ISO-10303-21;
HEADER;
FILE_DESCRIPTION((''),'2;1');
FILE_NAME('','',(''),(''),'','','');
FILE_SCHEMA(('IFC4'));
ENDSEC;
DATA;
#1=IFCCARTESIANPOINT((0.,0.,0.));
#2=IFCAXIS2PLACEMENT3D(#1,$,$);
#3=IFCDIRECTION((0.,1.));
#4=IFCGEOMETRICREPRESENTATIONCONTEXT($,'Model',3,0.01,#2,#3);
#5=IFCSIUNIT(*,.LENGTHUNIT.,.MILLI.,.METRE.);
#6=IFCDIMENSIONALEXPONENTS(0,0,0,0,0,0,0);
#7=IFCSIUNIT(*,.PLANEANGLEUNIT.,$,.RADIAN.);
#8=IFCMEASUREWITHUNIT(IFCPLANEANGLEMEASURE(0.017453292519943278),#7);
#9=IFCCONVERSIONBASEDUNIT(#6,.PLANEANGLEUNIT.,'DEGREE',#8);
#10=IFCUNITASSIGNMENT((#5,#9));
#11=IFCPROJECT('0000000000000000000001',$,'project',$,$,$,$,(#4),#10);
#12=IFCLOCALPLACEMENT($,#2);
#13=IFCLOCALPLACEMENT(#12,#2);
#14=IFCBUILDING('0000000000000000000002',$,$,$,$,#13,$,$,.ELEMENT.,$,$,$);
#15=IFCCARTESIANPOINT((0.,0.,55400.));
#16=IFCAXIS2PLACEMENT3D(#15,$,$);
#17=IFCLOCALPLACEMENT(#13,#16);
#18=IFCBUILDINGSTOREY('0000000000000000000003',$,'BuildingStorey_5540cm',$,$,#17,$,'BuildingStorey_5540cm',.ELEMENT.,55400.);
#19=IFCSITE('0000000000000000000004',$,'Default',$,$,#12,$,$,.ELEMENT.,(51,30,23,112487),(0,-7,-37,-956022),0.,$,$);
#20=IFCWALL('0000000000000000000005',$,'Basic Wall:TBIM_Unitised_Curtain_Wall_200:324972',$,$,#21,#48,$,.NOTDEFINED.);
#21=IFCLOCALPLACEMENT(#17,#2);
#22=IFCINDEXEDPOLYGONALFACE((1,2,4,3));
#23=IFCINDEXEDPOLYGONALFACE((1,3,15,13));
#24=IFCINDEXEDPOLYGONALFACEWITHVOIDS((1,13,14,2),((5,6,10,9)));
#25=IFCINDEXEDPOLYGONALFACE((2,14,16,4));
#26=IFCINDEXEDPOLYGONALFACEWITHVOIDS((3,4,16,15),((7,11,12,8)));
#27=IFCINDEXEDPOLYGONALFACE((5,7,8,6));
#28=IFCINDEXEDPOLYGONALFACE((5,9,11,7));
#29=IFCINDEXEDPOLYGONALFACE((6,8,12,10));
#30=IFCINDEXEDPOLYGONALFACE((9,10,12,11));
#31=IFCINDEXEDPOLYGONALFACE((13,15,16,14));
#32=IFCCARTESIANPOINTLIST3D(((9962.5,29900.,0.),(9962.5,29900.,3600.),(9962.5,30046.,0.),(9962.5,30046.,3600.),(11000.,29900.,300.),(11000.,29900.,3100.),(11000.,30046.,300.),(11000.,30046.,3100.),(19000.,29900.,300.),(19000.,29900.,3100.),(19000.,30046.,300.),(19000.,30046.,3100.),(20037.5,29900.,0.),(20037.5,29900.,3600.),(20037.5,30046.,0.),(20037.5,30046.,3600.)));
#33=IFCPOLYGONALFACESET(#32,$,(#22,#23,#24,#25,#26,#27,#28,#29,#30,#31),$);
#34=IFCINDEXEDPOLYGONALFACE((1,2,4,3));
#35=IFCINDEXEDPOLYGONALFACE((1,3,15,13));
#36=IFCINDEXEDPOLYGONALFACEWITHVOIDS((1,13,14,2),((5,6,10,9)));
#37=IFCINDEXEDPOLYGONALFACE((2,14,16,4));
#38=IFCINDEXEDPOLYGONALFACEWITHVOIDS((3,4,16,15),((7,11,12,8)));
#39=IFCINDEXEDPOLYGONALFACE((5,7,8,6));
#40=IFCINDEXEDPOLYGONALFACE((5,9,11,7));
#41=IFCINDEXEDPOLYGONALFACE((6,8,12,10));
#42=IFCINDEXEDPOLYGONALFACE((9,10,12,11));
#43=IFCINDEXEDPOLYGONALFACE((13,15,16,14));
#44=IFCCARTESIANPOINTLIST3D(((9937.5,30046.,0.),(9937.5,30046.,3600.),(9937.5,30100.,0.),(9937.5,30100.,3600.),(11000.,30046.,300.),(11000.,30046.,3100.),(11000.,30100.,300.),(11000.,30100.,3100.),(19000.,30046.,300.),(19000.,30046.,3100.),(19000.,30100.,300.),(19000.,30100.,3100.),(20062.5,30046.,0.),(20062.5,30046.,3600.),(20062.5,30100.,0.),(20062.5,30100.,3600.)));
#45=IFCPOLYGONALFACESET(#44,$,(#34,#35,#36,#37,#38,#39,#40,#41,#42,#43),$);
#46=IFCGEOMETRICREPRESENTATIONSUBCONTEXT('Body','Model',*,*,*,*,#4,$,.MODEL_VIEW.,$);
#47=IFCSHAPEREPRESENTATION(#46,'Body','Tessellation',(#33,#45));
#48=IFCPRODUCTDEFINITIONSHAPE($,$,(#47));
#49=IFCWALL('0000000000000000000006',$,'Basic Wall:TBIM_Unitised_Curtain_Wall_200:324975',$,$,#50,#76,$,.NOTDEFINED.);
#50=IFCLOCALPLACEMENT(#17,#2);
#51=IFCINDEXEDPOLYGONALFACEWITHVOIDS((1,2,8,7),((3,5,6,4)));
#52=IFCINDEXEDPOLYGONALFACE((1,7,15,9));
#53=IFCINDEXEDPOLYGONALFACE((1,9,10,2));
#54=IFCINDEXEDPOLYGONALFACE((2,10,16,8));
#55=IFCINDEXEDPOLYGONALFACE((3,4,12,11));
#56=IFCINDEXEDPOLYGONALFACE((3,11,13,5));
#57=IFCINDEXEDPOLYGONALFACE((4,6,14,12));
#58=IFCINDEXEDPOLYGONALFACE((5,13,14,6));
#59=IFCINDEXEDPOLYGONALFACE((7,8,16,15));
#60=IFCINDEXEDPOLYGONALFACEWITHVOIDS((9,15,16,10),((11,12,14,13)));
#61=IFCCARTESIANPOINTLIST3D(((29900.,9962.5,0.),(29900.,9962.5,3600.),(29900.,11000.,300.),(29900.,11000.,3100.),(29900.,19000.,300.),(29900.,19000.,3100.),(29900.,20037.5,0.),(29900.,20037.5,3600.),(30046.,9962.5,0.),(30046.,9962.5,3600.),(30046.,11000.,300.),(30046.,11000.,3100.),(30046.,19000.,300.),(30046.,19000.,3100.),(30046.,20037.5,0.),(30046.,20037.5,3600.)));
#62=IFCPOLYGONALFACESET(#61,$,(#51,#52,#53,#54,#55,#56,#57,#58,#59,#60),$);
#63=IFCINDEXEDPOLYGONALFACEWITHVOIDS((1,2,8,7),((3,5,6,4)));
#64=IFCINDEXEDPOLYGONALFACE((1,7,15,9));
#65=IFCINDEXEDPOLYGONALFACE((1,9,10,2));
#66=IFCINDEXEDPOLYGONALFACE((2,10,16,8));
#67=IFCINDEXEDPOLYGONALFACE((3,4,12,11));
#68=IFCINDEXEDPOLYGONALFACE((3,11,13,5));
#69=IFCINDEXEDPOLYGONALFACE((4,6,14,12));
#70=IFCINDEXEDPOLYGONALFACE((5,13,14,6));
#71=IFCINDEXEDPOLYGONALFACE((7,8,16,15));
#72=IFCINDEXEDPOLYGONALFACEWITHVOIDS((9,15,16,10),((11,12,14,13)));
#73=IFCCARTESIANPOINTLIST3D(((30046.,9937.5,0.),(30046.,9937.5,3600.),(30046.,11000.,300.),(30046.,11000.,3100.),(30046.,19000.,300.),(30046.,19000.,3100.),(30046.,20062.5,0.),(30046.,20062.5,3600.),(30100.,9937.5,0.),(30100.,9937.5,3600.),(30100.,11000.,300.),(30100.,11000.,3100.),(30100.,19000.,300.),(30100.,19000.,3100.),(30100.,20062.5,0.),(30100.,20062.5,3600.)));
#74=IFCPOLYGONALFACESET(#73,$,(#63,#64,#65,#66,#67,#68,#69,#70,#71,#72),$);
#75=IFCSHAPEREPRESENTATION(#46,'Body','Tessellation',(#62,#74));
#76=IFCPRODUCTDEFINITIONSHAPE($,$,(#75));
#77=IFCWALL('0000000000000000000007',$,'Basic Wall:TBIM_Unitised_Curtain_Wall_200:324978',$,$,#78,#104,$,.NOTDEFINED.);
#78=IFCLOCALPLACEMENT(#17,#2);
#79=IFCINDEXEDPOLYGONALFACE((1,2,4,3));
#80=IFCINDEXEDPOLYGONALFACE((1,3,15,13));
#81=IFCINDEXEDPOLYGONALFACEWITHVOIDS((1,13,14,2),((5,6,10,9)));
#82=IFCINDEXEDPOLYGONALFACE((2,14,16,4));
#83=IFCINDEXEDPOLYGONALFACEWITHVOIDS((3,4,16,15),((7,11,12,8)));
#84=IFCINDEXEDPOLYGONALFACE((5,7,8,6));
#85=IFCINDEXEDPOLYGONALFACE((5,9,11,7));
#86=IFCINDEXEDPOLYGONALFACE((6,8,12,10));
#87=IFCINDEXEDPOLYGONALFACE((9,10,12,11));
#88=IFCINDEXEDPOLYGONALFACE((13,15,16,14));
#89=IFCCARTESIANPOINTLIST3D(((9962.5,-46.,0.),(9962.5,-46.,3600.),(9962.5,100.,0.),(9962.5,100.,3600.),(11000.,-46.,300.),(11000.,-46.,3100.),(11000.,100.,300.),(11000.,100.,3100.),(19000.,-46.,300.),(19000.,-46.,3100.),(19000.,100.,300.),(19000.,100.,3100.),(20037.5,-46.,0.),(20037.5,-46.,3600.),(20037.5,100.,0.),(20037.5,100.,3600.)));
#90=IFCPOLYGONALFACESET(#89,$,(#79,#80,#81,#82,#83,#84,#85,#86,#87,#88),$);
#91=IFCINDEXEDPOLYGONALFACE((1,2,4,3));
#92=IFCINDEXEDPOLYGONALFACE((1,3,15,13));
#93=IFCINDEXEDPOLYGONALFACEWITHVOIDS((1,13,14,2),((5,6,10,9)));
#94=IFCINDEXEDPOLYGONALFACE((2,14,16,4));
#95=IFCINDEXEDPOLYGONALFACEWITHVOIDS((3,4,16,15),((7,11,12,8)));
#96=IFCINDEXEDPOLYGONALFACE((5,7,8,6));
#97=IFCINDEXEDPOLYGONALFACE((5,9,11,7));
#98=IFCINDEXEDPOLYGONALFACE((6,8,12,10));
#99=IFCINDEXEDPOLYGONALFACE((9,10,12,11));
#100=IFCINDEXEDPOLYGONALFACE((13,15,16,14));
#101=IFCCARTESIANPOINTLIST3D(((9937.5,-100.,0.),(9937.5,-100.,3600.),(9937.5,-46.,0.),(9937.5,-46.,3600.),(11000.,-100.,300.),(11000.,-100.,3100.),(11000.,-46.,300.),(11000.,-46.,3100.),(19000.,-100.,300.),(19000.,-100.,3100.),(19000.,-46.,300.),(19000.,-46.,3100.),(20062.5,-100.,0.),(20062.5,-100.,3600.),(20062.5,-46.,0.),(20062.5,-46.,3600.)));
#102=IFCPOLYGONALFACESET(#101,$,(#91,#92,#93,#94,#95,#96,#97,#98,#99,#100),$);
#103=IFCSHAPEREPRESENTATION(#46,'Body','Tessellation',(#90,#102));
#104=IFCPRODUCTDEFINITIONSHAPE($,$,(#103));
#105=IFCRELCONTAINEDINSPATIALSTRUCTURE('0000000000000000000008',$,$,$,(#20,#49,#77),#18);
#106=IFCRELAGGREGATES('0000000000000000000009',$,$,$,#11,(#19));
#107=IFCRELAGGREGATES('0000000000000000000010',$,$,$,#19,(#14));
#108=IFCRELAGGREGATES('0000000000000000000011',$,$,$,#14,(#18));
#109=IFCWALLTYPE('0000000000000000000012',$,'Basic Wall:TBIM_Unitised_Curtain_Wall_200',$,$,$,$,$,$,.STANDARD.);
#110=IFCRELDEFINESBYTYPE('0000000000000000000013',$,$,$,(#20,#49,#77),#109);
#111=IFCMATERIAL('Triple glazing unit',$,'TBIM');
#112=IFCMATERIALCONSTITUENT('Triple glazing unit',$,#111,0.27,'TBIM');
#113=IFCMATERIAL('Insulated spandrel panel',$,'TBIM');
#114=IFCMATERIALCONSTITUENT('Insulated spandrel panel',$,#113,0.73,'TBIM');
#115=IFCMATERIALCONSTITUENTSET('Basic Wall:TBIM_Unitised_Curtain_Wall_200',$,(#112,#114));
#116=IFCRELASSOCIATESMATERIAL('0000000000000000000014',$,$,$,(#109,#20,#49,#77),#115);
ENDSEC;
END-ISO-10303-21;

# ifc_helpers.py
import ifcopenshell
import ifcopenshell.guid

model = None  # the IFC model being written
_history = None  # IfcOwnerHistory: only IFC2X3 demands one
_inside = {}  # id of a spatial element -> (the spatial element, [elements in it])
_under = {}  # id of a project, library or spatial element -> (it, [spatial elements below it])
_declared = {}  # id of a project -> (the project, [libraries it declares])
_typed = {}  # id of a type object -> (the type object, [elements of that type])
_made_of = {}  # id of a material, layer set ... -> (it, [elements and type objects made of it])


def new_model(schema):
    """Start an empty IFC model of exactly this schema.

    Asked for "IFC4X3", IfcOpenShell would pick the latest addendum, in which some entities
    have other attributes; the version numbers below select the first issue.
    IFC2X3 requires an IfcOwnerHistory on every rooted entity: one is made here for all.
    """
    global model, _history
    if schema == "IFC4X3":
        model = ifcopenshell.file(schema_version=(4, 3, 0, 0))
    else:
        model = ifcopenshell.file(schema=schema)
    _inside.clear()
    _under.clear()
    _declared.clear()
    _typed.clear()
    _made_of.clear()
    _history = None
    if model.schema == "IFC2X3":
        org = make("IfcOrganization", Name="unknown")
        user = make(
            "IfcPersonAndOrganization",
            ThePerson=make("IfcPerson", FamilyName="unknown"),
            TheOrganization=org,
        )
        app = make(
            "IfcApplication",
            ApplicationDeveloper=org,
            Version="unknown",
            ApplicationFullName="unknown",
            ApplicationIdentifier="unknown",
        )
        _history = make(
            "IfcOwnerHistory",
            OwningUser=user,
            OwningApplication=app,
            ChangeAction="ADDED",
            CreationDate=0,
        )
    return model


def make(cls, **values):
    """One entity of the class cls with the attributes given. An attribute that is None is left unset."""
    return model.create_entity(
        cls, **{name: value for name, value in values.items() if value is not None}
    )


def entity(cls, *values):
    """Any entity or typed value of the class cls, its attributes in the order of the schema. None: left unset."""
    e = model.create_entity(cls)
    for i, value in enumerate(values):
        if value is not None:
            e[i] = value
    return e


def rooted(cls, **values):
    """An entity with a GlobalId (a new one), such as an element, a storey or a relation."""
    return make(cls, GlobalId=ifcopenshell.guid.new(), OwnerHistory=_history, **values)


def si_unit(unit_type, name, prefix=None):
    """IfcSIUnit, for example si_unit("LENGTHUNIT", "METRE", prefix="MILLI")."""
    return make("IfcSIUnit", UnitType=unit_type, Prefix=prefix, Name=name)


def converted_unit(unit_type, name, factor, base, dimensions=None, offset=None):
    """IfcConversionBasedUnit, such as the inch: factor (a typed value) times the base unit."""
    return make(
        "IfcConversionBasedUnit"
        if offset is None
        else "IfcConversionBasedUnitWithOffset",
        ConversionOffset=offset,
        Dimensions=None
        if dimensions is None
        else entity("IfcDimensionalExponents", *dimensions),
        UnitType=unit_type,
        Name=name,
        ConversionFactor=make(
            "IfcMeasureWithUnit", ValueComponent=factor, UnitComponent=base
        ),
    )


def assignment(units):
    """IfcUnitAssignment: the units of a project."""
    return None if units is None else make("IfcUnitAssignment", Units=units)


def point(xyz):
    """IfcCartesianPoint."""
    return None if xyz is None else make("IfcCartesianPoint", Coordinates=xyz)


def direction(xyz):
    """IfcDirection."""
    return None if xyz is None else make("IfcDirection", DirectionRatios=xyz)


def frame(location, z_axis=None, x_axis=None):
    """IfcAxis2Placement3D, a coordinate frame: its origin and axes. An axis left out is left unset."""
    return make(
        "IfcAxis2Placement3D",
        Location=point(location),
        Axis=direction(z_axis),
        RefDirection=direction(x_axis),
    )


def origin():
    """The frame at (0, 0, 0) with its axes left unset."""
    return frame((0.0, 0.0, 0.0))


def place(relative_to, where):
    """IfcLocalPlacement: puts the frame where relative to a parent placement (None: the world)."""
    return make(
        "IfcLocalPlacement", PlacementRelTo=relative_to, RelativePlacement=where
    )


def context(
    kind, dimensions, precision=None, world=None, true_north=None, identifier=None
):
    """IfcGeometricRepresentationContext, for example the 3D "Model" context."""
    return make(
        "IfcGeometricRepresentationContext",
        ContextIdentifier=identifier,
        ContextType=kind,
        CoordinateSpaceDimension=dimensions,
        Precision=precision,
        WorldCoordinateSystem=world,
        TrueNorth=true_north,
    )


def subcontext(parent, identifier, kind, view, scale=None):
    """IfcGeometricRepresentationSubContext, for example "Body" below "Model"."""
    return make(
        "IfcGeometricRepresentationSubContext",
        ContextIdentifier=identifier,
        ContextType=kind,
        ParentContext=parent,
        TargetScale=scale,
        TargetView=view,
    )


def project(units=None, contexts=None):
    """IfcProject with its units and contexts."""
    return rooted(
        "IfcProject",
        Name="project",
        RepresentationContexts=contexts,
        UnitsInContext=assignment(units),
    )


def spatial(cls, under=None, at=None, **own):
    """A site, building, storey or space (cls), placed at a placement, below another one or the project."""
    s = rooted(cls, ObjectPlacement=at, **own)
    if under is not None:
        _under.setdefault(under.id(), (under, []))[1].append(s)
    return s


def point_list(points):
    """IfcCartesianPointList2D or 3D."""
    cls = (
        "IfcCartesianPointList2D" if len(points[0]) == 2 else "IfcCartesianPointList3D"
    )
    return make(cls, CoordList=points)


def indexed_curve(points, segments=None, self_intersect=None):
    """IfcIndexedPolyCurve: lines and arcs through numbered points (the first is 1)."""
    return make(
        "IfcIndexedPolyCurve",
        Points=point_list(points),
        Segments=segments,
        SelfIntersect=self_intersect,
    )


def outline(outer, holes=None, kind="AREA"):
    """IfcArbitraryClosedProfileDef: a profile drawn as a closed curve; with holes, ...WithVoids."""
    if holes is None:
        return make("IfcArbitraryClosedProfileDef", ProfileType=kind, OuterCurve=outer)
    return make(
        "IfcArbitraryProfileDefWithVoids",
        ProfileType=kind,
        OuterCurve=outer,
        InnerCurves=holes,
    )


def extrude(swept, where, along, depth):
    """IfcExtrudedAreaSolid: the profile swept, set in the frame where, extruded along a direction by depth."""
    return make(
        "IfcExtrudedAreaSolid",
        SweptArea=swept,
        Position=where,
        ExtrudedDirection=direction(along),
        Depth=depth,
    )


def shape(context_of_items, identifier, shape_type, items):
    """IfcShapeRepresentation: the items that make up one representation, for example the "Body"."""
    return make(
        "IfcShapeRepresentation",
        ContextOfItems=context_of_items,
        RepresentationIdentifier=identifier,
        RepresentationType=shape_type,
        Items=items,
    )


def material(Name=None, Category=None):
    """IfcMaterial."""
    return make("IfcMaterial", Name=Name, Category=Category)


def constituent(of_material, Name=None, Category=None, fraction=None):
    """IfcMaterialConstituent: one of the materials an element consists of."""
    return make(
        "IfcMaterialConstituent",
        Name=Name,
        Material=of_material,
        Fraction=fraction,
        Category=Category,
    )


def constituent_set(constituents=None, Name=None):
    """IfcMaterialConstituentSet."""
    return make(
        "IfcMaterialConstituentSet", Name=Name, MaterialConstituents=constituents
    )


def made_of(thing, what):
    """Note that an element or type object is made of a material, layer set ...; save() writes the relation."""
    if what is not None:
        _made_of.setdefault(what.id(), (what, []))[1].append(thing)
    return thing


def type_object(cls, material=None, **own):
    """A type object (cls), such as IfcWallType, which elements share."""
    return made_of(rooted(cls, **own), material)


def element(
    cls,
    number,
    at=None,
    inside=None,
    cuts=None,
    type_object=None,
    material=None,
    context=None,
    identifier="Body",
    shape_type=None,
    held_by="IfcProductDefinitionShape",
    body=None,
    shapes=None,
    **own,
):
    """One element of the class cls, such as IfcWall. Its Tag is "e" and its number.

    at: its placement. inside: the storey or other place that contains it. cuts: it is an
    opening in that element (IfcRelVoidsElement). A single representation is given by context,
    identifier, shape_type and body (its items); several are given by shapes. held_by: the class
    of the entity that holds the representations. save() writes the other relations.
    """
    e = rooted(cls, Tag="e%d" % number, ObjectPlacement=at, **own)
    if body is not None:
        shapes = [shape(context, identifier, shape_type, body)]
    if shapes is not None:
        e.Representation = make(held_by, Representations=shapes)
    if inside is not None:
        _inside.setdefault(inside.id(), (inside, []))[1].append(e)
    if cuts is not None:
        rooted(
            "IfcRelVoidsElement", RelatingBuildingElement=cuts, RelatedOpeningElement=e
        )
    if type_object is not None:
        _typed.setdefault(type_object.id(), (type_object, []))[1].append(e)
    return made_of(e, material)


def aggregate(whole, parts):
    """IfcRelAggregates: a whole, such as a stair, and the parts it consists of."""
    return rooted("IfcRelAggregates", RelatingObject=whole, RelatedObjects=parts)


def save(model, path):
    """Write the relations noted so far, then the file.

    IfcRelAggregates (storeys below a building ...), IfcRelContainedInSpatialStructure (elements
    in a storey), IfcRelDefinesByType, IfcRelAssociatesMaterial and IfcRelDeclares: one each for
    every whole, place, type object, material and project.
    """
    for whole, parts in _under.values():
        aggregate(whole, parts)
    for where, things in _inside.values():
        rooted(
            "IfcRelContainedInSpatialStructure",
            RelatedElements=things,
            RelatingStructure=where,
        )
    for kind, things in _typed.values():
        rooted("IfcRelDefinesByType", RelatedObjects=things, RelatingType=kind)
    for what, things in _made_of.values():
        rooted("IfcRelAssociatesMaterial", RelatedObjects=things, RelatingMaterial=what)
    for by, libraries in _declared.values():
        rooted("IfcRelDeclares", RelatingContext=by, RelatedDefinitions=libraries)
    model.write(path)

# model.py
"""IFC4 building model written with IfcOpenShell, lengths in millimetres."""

from ifc_helpers import new_model, entity, si_unit, converted_unit, direction, frame, origin, place, context, subcontext, project, spatial, indexed_curve, outline, extrude, material, constituent, constituent_set, type_object, element, save


model = new_model("IFC4")

# Units and contexts
model_context = context("Model", 3, precision=0.01, world=origin(), true_north=direction((0.0, 1.0)))
body_context = subcontext(model_context, "Body", "Model", "MODEL_VIEW")
ifc_project = project(units=[si_unit("LENGTHUNIT", "METRE", prefix="MILLI"), converted_unit("PLANEANGLEUNIT", "DEGREE", entity("IfcPlaneAngleMeasure", 0.017453292519943278), si_unit("PLANEANGLEUNIT", "RADIAN"), dimensions=[0, 0, 0, 0, 0, 0, 0])], contexts=[model_context])

# Site, building, storey
site_placement = place(None, origin())
site = spatial("IfcSite", under=ifc_project, at=site_placement, Name="Default", CompositionType="ELEMENT", RefLatitude=(51, 30, 23, 112487), RefLongitude=(0, -7, -37, -956022), RefElevation=0.0)
building_placement = place(site_placement, origin())
building = spatial("IfcBuilding", under=site, at=building_placement, CompositionType="ELEMENT")
storey_placement = place(building_placement, frame((0.0, 0.0, 55400.0)))
storey = spatial("IfcBuildingStorey", under=building, at=storey_placement, Name="BuildingStorey_5540cm", LongName="BuildingStorey_5540cm", CompositionType="ELEMENT", Elevation=55400.0)

# Walls, openings
ifc_material_1 = material(Name="Triple glazing unit", Category="TBIM")
ifc_constituent_1 = constituent(ifc_material_1, Name="Triple glazing unit", Category="TBIM", fraction=0.27)
ifc_material_2 = material(Name="Insulated spandrel panel", Category="TBIM")
ifc_constituent_2 = constituent(ifc_material_2, Name="Insulated spandrel panel", Category="TBIM", fraction=0.73)
ifc_constituent_set_1 = constituent_set(constituents=[ifc_constituent_1, ifc_constituent_2], Name="Basic Wall:TBIM_Unitised_Curtain_Wall_200")
wall_type_1 = type_object("IfcWallType", Name="Basic Wall:TBIM_Unitised_Curtain_Wall_200", PredefinedType="STANDARD", material=ifc_constituent_set_1)
wall_1_placement = place(storey_placement, frame((9937.5, 30000.0, 0.0)))
wall_1 = element("IfcWall", 1, at=wall_1_placement, inside=storey, type_object=wall_type_1, material=ifc_constituent_set_1, Name="Basic Wall:TBIM_Unitised_Curtain_Wall_200:324972", PredefinedType="NOTDEFINED", context=body_context, shape_type="SweptSolid", body=[
    extrude(outline(indexed_curve([(-1800.0, -5037.5), (1800.0, -5037.5), (1800.0, -4937.5), (1800.0, 4937.5), (1800.0, 5037.5), (-1800.0, 5037.5), (-1800.0, 4937.5), (-1800.0, -4937.5), (-1800.0, -5037.5)], self_intersect=False), holes=[indexed_curve([(1300.0, -4000.0), (-1500.0, -4000.0), (-1500.0, 4000.0), (1300.0, 4000.0), (1300.0, -4000.0)], self_intersect=False)]), frame((5062.5, -100.0, 1800.0), z_axis=(0.0, 1.0, 0.0), x_axis=(0.0, 0.0, 1.0)), (0.0, 0.0, 1.0), 146.0),
    extrude(outline(indexed_curve([(-1800.0, -5062.5), (1800.0, -5062.5), (1800.0, 5062.5), (-1800.0, 5062.5), (-1800.0, -5062.5)], self_intersect=False), holes=[indexed_curve([(-1500.0, -4000.0), (-1500.0, 4000.0), (1300.0, 4000.0), (1300.0, -4000.0), (-1500.0, -4000.0)], self_intersect=False)]), frame((5062.5, 46.0, 1800.0), z_axis=(0.0, 1.0, 0.0), x_axis=(0.0, 0.0, 1.0)), (0.0, 0.0, 1.0), 54.0),
])
opening_1_placement = place(wall_1_placement, frame((1062.5, -100.0, 300.0)))
element("IfcOpeningElement", 2, at=opening_1_placement, cuts=wall_1, PredefinedType="OPENING", context=body_context, shape_type="SweptSolid", body=[
    extrude(outline(indexed_curve([(2800.0, 0.0), (2800.0, 8000.0), (0.0, 8000.0), (0.0, 0.0), (2800.0, 0.0)], self_intersect=False)), frame((0.0, 0.0, 0.0), z_axis=(0.0, 1.0, 0.0), x_axis=(0.0, 0.0, 1.0)), (0.0, 0.0, 1.0), 200.0),
])
wall_2_placement = place(storey_placement, frame((30000.0, 9937.5, 0.0), z_axis=(0.0, 0.0, 1.0), x_axis=(0.0, 1.0, 0.0)))
wall_2 = element("IfcWall", 3, at=wall_2_placement, inside=storey, type_object=wall_type_1, material=ifc_constituent_set_1, Name="Basic Wall:TBIM_Unitised_Curtain_Wall_200:324975", PredefinedType="NOTDEFINED", context=body_context, shape_type="SweptSolid", body=[
    extrude(outline(indexed_curve([(-5037.5, -1800.0), (-4937.5, -1800.0), (4937.5, -1800.0), (5037.5, -1800.0), (5037.5, 1800.0), (4937.5, 1800.0), (-4937.5, 1800.0), (-5037.5, 1800.0), (-5037.5, -1800.0)], self_intersect=False), holes=[indexed_curve([(-4000.0, 1300.0), (4000.0, 1300.0), (4000.0, -1500.0), (-4000.0, -1500.0), (-4000.0, 1300.0)], self_intersect=False)]), frame((5062.5, 100.0, 1800.0), z_axis=(0.0, -1.0, 0.0), x_axis=(1.0, 0.0, 0.0)), (0.0, 0.0, 1.0), 146.0),
    extrude(outline(indexed_curve([(-1800.0, -5062.5), (1800.0, -5062.5), (1800.0, 5062.5), (-1800.0, 5062.5), (-1800.0, -5062.5)], self_intersect=False), holes=[indexed_curve([(1300.0, 4000.0), (1300.0, -4000.0), (-1500.0, -4000.0), (-1500.0, 4000.0), (1300.0, 4000.0)], self_intersect=False)]), frame((5062.5, -46.0, 1800.0), z_axis=(0.0, -1.0, 0.0), x_axis=(0.0, 0.0, 1.0)), (0.0, 0.0, 1.0), 54.0),
])
opening_2_placement = place(wall_2_placement, frame((1062.5, -100.0, 300.0)))
element("IfcOpeningElement", 4, at=opening_2_placement, cuts=wall_2, PredefinedType="OPENING", context=body_context, shape_type="SweptSolid", body=[
    extrude(outline(indexed_curve([(2800.0, 0.0), (2800.0, 8000.0), (0.0, 8000.0), (0.0, 0.0), (2800.0, 0.0)], self_intersect=False)), frame((0.0, 0.0, 0.0), z_axis=(0.0, 1.0, 0.0), x_axis=(0.0, 0.0, 1.0)), (0.0, 0.0, 1.0), 200.0),
])
wall_3_placement = place(storey_placement, frame((9937.5, 0.0, 0.0)))
wall_3 = element("IfcWall", 5, at=wall_3_placement, inside=storey, type_object=wall_type_1, material=ifc_constituent_set_1, Name="Basic Wall:TBIM_Unitised_Curtain_Wall_200:324978", PredefinedType="NOTDEFINED", context=body_context, shape_type="SweptSolid", body=[
    extrude(outline(indexed_curve([(-1800.0, -5037.5), (1800.0, -5037.5), (1800.0, 5037.5), (-1800.0, 5037.5), (-1800.0, -5037.5)], self_intersect=False), holes=[indexed_curve([(-1500.0, -4000.0), (-1500.0, 4000.0), (1300.0, 4000.0), (1300.0, -4000.0), (-1500.0, -4000.0)], self_intersect=False)]), frame((5062.5, -46.0, 1800.0), z_axis=(0.0, 1.0, 0.0), x_axis=(0.0, 0.0, 1.0)), (0.0, 0.0, 1.0), 146.0),
    extrude(outline(indexed_curve([(-1800.0, -5062.5), (1800.0, -5062.5), (1800.0, 5062.5), (-1800.0, 5062.5), (-1800.0, -5062.5)], self_intersect=False), holes=[indexed_curve([(1300.0, -4000.0), (-1500.0, -4000.0), (-1500.0, 4000.0), (1300.0, 4000.0), (1300.0, -4000.0)], self_intersect=False)]), frame((5062.5, -100.0, 1800.0), z_axis=(0.0, 1.0, 0.0), x_axis=(0.0, 0.0, 1.0)), (0.0, 0.0, 1.0), 54.0),
])
opening_3_placement = place(wall_3_placement, frame((1062.5, -100.0, 300.0)))
element("IfcOpeningElement", 6, at=opening_3_placement, cuts=wall_3, PredefinedType="OPENING", context=body_context, shape_type="SweptSolid", body=[
    extrude(outline(indexed_curve([(2800.0, 0.0), (2800.0, 8000.0), (0.0, 8000.0), (0.0, 0.0), (2800.0, 0.0)], self_intersect=False)), frame((0.0, 0.0, 0.0), z_axis=(0.0, 1.0, 0.0), x_axis=(0.0, 0.0, 1.0)), (0.0, 0.0, 1.0), 200.0),
])

save(model, "model.ifc")
